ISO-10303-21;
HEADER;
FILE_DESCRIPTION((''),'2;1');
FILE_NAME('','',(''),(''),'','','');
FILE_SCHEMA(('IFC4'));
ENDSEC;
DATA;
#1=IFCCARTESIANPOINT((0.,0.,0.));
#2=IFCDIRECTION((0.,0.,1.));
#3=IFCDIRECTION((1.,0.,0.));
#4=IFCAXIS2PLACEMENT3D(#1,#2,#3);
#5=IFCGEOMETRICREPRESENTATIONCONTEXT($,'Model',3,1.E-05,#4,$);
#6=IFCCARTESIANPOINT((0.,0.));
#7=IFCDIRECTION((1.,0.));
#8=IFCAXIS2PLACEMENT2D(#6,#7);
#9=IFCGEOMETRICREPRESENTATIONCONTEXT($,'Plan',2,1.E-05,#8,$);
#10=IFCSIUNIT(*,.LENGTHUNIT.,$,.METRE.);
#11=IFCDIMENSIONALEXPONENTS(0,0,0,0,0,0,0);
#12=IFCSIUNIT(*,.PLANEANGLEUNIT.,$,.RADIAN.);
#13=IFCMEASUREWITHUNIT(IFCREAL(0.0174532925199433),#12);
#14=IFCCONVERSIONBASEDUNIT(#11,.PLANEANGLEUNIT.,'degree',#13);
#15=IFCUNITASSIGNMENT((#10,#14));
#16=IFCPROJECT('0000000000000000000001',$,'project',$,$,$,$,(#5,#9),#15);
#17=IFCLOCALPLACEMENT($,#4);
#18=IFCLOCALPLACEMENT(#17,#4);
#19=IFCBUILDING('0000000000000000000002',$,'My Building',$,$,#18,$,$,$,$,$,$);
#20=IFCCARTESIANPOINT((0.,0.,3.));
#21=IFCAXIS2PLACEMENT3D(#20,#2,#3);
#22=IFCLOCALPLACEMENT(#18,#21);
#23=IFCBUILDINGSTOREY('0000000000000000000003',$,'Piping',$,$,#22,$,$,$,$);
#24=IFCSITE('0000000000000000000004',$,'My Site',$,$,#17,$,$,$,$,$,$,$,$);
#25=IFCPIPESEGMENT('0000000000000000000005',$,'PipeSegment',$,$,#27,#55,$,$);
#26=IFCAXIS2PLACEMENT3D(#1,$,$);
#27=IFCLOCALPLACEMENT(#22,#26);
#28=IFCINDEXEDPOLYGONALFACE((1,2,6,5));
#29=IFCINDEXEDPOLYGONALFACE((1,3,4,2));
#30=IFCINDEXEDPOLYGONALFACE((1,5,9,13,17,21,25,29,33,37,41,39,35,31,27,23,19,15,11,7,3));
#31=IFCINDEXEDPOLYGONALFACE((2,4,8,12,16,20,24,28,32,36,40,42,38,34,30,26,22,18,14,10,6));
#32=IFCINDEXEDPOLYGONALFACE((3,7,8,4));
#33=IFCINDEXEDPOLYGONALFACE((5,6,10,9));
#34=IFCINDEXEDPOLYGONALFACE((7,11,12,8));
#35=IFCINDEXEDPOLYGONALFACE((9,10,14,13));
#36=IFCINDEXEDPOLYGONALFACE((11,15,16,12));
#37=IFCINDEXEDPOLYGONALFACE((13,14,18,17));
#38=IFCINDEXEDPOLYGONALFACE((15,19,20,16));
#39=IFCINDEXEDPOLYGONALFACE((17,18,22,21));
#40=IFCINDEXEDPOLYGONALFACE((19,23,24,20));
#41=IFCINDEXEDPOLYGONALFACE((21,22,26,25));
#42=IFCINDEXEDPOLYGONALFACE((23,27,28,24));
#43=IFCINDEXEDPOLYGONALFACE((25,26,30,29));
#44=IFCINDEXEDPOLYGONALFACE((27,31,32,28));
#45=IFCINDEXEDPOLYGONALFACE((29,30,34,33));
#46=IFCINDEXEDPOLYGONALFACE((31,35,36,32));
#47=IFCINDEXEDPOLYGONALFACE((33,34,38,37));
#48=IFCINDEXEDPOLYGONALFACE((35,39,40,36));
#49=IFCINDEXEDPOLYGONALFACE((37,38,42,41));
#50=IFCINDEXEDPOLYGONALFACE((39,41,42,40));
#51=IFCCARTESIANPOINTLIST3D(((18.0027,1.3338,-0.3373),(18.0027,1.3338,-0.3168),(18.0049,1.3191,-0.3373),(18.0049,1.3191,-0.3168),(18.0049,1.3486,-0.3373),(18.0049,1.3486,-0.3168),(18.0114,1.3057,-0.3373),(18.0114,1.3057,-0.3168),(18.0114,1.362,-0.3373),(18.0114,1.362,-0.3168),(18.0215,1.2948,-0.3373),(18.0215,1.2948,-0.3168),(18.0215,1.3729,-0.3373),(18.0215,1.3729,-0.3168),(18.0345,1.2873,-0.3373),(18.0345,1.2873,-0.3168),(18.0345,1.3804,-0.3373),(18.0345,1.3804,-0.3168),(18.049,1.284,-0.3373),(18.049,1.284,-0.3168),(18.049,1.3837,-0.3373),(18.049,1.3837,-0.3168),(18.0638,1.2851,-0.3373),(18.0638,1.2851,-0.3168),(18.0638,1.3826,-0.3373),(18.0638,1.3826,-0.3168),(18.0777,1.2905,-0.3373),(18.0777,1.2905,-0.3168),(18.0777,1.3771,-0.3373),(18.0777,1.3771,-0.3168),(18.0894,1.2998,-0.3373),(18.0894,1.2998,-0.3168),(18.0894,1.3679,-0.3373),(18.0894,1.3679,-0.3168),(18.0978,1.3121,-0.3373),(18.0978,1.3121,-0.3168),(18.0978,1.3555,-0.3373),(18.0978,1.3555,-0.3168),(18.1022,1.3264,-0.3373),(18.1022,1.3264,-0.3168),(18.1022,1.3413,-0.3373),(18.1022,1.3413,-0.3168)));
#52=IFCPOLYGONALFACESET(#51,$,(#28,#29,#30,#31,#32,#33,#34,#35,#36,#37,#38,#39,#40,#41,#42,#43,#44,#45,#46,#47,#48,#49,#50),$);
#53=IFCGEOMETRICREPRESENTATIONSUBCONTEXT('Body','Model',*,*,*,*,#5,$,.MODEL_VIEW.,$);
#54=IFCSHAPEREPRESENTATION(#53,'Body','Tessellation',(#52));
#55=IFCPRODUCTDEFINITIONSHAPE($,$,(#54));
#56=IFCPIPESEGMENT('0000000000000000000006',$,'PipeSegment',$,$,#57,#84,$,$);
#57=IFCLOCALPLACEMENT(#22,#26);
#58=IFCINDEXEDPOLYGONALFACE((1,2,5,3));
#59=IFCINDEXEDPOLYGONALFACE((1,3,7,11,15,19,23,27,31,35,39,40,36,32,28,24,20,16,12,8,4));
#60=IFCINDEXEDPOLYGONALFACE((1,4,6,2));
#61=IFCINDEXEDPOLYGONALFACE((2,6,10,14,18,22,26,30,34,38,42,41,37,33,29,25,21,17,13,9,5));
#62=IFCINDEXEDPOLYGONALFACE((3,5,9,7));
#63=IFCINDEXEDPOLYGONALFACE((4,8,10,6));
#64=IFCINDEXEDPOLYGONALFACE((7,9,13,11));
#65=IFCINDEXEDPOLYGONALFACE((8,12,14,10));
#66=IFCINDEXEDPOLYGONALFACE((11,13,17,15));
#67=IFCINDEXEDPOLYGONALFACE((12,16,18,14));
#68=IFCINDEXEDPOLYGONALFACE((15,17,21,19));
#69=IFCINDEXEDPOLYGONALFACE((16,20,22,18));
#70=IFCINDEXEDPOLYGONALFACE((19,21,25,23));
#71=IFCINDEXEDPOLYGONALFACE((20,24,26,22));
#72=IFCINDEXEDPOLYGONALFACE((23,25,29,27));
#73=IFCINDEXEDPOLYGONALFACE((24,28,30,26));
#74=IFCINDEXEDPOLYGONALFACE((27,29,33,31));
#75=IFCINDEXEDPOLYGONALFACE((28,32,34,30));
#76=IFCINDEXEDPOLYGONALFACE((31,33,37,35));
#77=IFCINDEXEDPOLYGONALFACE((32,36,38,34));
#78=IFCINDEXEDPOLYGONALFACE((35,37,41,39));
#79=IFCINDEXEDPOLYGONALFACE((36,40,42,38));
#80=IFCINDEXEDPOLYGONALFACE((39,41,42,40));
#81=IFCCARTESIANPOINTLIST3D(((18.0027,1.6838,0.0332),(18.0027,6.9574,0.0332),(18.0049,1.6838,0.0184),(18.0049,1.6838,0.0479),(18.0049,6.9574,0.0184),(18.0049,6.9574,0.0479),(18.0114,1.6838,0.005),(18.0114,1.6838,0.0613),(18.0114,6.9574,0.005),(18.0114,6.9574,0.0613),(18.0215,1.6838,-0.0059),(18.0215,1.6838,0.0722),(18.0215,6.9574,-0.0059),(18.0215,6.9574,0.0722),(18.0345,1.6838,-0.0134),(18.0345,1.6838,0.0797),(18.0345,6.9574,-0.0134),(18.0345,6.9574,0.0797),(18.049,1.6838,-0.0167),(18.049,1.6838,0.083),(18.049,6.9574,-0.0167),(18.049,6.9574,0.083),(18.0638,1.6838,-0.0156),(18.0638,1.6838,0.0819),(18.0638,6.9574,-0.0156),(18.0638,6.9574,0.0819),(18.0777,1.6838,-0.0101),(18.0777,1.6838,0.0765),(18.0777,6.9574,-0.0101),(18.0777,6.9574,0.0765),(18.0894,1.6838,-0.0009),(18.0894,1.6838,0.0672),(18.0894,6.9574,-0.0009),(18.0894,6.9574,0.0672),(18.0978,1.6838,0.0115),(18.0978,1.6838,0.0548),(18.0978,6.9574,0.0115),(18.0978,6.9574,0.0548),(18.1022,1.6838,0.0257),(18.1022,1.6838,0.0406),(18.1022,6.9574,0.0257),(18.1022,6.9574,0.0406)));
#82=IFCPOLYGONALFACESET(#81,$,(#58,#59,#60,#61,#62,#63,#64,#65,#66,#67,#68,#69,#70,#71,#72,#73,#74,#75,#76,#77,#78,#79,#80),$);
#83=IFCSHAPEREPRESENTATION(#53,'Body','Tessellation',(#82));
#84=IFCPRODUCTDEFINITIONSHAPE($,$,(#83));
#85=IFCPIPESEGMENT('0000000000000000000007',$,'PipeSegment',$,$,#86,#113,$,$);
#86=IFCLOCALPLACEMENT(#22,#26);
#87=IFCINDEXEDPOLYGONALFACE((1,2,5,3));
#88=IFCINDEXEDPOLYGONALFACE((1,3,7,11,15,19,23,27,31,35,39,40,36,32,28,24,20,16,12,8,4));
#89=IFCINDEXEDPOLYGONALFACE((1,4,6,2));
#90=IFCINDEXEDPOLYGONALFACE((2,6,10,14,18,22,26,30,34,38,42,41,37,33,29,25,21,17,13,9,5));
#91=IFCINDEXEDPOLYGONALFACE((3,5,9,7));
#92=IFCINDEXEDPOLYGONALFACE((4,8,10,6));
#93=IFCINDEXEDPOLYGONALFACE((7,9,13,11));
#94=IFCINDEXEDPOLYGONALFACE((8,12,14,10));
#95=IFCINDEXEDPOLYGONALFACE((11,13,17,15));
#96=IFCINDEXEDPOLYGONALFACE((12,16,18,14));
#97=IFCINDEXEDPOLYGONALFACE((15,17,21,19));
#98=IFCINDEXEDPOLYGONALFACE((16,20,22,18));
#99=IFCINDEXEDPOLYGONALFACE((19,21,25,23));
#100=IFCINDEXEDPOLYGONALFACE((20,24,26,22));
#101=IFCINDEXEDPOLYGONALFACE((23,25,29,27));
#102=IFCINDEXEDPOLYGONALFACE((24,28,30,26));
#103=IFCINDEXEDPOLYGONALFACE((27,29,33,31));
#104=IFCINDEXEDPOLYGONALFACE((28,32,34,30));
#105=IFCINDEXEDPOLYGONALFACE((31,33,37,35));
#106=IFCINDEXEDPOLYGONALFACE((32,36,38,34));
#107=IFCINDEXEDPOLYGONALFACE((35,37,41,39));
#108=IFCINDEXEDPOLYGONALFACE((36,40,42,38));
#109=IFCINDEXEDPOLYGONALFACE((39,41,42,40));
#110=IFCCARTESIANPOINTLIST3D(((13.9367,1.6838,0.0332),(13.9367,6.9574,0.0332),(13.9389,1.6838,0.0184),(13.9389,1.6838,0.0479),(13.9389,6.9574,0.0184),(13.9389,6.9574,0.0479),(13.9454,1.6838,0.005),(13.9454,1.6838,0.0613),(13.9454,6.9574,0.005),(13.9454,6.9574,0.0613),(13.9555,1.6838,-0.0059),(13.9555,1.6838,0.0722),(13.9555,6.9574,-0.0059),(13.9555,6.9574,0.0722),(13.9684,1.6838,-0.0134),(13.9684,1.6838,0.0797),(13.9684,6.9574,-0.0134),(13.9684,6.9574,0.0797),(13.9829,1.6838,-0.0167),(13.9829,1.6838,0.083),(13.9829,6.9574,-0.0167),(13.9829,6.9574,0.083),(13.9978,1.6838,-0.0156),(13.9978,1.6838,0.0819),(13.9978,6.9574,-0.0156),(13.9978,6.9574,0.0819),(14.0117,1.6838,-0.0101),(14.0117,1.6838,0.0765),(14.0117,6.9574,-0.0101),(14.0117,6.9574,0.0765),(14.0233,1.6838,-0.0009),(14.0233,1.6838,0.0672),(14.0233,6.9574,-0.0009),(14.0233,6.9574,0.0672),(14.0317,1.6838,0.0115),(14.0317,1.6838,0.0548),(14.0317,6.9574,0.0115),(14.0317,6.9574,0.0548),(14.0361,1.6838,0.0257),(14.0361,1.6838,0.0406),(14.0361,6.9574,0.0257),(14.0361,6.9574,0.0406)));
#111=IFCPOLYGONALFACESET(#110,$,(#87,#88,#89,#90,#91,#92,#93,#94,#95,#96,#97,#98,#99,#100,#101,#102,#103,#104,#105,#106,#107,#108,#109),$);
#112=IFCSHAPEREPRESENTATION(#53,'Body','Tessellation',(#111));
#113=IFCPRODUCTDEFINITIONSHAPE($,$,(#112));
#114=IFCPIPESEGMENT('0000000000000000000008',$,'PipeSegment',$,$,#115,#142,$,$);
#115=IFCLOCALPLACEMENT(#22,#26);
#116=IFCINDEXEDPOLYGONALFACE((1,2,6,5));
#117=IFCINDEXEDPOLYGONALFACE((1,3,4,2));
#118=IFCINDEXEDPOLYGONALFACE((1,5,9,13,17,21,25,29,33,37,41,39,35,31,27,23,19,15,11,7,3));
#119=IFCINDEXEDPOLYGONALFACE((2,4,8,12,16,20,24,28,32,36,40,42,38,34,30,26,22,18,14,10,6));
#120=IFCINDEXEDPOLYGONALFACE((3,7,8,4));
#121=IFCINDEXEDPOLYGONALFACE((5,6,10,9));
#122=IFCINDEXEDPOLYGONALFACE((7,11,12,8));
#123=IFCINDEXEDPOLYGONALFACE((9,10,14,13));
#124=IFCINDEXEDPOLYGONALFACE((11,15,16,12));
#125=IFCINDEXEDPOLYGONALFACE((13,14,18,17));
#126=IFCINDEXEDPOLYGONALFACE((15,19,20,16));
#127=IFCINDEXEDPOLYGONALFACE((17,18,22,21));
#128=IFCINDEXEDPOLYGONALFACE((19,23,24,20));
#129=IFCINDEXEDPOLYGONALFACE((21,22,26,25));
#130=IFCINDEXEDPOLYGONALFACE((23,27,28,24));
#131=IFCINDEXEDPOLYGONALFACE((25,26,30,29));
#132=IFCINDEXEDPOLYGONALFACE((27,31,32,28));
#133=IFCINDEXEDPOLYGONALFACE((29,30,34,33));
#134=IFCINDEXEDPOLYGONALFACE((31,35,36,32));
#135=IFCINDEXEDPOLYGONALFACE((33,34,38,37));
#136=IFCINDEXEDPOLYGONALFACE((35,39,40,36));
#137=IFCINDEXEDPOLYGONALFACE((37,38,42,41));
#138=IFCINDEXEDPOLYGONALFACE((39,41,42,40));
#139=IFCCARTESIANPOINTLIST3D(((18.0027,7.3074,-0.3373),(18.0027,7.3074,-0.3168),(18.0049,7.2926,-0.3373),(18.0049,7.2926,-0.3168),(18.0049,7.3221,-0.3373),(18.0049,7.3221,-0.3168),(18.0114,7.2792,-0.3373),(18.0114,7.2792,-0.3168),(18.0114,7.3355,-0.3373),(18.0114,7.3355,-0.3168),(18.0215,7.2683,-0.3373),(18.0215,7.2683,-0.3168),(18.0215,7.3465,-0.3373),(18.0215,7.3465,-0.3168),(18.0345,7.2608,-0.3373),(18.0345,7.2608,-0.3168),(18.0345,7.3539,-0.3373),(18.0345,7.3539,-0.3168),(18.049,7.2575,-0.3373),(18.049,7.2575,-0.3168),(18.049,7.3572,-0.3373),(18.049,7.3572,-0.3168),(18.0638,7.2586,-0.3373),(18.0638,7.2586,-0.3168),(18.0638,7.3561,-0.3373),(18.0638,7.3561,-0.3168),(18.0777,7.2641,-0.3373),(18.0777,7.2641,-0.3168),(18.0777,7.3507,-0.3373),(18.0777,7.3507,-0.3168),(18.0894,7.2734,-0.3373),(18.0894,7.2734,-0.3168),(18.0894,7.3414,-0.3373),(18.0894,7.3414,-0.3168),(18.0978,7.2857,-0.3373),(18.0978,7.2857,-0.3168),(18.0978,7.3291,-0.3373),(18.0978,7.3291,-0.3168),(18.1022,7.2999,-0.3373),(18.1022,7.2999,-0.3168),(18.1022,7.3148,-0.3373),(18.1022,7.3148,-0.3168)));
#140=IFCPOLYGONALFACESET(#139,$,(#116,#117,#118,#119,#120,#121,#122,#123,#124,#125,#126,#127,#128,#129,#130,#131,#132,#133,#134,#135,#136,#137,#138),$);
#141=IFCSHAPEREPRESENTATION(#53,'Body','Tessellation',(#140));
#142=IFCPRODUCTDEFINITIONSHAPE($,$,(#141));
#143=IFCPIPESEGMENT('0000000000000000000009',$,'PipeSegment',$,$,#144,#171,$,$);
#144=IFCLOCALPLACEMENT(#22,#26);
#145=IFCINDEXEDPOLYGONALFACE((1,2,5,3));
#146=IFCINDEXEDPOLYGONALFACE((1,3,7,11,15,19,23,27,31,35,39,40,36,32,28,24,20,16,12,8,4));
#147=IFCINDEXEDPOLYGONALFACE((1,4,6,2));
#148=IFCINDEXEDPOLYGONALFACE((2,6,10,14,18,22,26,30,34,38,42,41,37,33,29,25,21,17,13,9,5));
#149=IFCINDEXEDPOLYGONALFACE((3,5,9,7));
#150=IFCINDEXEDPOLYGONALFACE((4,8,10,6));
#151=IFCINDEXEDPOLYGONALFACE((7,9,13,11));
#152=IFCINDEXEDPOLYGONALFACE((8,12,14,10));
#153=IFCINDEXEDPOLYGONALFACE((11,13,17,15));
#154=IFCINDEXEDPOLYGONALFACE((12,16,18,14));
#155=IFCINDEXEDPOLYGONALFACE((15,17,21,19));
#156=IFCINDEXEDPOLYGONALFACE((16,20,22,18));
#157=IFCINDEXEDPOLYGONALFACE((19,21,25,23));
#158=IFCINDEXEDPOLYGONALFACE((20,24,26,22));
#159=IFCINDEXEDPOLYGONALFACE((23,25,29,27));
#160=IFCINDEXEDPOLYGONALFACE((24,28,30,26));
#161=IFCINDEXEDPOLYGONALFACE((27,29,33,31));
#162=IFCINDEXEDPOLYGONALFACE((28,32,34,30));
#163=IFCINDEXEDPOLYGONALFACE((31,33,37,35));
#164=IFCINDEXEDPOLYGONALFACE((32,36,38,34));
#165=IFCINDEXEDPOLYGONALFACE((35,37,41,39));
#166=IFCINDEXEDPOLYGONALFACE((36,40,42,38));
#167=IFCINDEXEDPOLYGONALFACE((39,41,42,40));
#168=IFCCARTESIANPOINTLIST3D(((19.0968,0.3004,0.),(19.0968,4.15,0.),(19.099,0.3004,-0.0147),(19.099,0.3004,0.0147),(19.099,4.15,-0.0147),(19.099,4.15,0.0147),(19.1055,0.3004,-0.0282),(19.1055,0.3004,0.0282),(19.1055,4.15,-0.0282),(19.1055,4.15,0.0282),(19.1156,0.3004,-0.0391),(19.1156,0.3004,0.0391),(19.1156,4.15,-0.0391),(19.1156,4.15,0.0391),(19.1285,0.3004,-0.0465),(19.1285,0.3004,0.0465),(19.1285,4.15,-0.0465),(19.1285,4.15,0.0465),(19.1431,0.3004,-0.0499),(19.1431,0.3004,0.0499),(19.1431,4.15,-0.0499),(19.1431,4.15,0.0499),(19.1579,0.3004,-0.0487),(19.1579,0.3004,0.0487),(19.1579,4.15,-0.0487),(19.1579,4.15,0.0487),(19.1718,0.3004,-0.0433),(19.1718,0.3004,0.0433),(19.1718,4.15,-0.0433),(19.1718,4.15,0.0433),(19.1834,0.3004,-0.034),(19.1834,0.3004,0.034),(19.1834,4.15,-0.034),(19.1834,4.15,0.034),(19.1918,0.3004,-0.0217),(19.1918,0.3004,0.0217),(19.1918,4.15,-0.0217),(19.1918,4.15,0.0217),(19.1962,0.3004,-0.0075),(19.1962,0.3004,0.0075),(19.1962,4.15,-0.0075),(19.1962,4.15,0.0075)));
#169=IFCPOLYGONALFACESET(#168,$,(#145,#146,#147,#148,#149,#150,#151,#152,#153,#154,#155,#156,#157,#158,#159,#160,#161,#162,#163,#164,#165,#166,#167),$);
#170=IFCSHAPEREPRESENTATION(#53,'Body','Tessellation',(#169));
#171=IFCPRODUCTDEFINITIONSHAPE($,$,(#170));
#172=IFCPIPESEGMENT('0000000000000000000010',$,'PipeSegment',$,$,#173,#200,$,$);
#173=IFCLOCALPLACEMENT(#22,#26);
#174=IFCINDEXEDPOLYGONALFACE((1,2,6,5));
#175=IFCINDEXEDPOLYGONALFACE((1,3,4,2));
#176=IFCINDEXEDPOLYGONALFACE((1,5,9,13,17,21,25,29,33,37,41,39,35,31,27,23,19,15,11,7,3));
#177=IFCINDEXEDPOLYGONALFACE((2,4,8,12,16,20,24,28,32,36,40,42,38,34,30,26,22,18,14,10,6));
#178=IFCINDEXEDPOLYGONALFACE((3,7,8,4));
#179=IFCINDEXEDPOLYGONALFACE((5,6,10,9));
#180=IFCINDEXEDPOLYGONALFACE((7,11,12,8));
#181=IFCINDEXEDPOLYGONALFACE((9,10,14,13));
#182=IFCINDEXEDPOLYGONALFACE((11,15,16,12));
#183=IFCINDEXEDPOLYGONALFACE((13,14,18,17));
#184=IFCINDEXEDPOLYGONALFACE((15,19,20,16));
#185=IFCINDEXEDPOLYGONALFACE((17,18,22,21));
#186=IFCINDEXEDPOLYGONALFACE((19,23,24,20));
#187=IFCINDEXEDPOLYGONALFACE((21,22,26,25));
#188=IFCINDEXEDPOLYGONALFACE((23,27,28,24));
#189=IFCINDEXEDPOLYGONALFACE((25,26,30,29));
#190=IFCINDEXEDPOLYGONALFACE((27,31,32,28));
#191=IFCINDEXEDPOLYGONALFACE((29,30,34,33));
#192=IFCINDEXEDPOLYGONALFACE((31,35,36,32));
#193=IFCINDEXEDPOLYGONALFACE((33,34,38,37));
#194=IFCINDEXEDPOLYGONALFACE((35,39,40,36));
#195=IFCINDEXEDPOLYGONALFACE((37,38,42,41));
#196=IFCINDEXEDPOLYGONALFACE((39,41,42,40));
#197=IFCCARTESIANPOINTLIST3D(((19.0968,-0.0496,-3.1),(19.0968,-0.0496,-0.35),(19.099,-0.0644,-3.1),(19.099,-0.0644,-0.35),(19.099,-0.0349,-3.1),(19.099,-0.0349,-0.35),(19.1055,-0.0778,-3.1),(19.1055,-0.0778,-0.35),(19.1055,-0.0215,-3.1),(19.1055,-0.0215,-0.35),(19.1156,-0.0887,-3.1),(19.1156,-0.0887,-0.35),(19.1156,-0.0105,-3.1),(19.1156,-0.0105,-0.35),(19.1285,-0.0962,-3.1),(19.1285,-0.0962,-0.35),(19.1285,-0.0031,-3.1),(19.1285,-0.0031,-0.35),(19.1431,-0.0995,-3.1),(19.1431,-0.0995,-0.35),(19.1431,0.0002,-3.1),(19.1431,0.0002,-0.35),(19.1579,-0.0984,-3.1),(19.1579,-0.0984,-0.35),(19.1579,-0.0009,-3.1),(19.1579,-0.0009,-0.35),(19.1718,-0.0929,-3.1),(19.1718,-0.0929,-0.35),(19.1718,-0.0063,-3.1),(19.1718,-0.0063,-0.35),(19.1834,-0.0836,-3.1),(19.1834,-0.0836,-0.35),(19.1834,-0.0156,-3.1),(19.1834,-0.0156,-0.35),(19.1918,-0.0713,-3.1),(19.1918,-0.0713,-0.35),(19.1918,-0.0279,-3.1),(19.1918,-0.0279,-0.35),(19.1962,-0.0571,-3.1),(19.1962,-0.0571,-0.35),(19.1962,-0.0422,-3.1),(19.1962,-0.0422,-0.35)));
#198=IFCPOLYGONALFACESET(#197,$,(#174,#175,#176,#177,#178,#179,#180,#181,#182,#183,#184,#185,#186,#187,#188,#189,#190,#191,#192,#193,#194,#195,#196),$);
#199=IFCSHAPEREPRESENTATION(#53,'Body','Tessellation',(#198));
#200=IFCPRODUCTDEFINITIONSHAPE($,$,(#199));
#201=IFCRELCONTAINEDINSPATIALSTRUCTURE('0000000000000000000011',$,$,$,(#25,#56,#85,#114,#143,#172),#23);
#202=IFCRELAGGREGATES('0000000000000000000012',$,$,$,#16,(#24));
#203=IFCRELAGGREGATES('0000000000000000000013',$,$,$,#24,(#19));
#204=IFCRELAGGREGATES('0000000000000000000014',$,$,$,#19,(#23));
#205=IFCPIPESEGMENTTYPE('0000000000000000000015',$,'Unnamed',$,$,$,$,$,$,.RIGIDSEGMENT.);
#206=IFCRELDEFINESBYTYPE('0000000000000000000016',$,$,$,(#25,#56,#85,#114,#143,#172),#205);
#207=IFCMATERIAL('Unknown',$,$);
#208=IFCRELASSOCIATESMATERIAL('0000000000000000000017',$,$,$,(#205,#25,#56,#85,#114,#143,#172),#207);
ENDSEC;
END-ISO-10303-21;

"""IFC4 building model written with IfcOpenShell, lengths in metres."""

from ifc_helpers import new_model, entity, si_unit, converted_unit, frame, origin_with_axes, origin_2d_with_axis, place, context, subcontext, project, spatial, circle, extrude, material, material_profile, profile_set, profile_usage, type_object, element, save


model = new_model("IFC4")

# Units and contexts
model_context = context("Model", 3, precision=1e-05, world=origin_with_axes())
plan_context = context("Plan", 2, precision=1e-05, world=origin_2d_with_axis())
body_context = subcontext(model_context, "Body", "Model", "MODEL_VIEW")
ifc_project = project(units=[si_unit("LENGTHUNIT", "METRE"), converted_unit("PLANEANGLEUNIT", "degree", entity("IfcReal", 0.0174532925199433), si_unit("PLANEANGLEUNIT", "RADIAN"), dimensions=[0, 0, 0, 0, 0, 0, 0])], contexts=[model_context, plan_context])

# Site, building, storey
site_placement = place(None, origin_with_axes())
site = spatial("IfcSite", under=ifc_project, at=site_placement, Name="My Site")
building_placement = place(site_placement, origin_with_axes())
building = spatial("IfcBuilding", under=site, at=building_placement, Name="My Building")
storey_placement = place(building_placement, frame((0.0, 0.0, 3.0), z_axis=(0.0, 0.0, 1.0), x_axis=(1.0, 0.0, 0.0)))
storey = spatial("IfcBuildingStorey", under=building, at=storey_placement, Name="Piping")

# Pipe segments
ifc_material = material(Name="Unknown")
ifc_material_profile = material_profile(ifc_material, circle(Radius=0.05))
ifc_profile_set = profile_set([ifc_material_profile])
pipe_segment_type = type_object("IfcPipeSegmentType", Name="Unnamed", PredefinedType="RIGIDSEGMENT", material=ifc_profile_set)
ifc_profile_usage_1 = profile_usage(ifc_profile_set, cardinal=5)
pipe_segment_1_placement = place(storey_placement, frame((18.0527, 1.3338, -0.3168), z_axis=(0.0, 0.0, -1.0), x_axis=(-1.0, 0.0, 0.0)))
element("IfcPipeSegment", 1, at=pipe_segment_1_placement, inside=storey, type_object=pipe_segment_type, material=ifc_profile_usage_1, Name="PipeSegment", context=body_context, shape_type="SweptSolid", body=[
    extrude(circle(Radius=0.05), origin_with_axes(), (0.0, 0.0, 1.0), 0.0204),
])
ifc_profile_usage_2 = profile_usage(ifc_profile_set, cardinal=5)
pipe_segment_2_placement = place(storey_placement, frame((18.0527, 1.6838, 0.0332), z_axis=(0.0, 1.0, 0.0), x_axis=(-1.0, 0.0, 0.0)))
element("IfcPipeSegment", 2, at=pipe_segment_2_placement, inside=storey, type_object=pipe_segment_type, material=ifc_profile_usage_2, Name="PipeSegment", context=body_context, shape_type="SweptSolid", body=[
    extrude(circle(Radius=0.05), origin_with_axes(), (0.0, 0.0, 1.0), 5.2735),
])
ifc_profile_usage_3 = profile_usage(ifc_profile_set, cardinal=5)
pipe_segment_3_placement = place(storey_placement, frame((13.9867, 1.6838, 0.0332), z_axis=(0.0, 1.0, 0.0), x_axis=(-1.0, 0.0, 0.0)))
element("IfcPipeSegment", 3, at=pipe_segment_3_placement, inside=storey, type_object=pipe_segment_type, material=ifc_profile_usage_3, Name="PipeSegment", context=body_context, shape_type="SweptSolid", body=[
    extrude(circle(Radius=0.05), origin_with_axes(), (0.0, 0.0, 1.0), 5.2735),
])
ifc_profile_usage_4 = profile_usage(ifc_profile_set, cardinal=5)
pipe_segment_4_placement = place(storey_placement, frame((18.0527, 7.3074, -0.3168), z_axis=(0.0, 0.0, -1.0), x_axis=(-1.0, 0.0, 0.0)))
element("IfcPipeSegment", 4, at=pipe_segment_4_placement, inside=storey, type_object=pipe_segment_type, material=ifc_profile_usage_4, Name="PipeSegment", context=body_context, shape_type="SweptSolid", body=[
    extrude(circle(Radius=0.05), origin_with_axes(), (0.0, 0.0, 1.0), 0.0204),
])
ifc_profile_usage_5 = profile_usage(ifc_profile_set, cardinal=5)
pipe_segment_5_placement = place(storey_placement, frame((19.1468, 0.3004, 0.0), z_axis=(0.0, 1.0, 0.0), x_axis=(-1.0, 0.0, 0.0)))
element("IfcPipeSegment", 5, at=pipe_segment_5_placement, inside=storey, type_object=pipe_segment_type, material=ifc_profile_usage_5, Name="PipeSegment", context=body_context, shape_type="SweptSolid", body=[
    extrude(circle(Radius=0.05), origin_with_axes(), (0.0, 0.0, 1.0), 3.8496),
])
ifc_profile_usage_6 = profile_usage(ifc_profile_set, cardinal=5)
pipe_segment_6_placement = place(storey_placement, frame((19.1468, -0.0496, -0.35), z_axis=(0.0, 0.0, -1.0), x_axis=(-1.0, 0.0, 0.0)))
element("IfcPipeSegment", 6, at=pipe_segment_6_placement, inside=storey, type_object=pipe_segment_type, material=ifc_profile_usage_6, Name="PipeSegment", context=body_context, shape_type="SweptSolid", body=[
    extrude(circle(Radius=0.05), origin_with_axes(), (0.0, 0.0, 1.0), 2.75),
])

save(model, "model.ifc")
